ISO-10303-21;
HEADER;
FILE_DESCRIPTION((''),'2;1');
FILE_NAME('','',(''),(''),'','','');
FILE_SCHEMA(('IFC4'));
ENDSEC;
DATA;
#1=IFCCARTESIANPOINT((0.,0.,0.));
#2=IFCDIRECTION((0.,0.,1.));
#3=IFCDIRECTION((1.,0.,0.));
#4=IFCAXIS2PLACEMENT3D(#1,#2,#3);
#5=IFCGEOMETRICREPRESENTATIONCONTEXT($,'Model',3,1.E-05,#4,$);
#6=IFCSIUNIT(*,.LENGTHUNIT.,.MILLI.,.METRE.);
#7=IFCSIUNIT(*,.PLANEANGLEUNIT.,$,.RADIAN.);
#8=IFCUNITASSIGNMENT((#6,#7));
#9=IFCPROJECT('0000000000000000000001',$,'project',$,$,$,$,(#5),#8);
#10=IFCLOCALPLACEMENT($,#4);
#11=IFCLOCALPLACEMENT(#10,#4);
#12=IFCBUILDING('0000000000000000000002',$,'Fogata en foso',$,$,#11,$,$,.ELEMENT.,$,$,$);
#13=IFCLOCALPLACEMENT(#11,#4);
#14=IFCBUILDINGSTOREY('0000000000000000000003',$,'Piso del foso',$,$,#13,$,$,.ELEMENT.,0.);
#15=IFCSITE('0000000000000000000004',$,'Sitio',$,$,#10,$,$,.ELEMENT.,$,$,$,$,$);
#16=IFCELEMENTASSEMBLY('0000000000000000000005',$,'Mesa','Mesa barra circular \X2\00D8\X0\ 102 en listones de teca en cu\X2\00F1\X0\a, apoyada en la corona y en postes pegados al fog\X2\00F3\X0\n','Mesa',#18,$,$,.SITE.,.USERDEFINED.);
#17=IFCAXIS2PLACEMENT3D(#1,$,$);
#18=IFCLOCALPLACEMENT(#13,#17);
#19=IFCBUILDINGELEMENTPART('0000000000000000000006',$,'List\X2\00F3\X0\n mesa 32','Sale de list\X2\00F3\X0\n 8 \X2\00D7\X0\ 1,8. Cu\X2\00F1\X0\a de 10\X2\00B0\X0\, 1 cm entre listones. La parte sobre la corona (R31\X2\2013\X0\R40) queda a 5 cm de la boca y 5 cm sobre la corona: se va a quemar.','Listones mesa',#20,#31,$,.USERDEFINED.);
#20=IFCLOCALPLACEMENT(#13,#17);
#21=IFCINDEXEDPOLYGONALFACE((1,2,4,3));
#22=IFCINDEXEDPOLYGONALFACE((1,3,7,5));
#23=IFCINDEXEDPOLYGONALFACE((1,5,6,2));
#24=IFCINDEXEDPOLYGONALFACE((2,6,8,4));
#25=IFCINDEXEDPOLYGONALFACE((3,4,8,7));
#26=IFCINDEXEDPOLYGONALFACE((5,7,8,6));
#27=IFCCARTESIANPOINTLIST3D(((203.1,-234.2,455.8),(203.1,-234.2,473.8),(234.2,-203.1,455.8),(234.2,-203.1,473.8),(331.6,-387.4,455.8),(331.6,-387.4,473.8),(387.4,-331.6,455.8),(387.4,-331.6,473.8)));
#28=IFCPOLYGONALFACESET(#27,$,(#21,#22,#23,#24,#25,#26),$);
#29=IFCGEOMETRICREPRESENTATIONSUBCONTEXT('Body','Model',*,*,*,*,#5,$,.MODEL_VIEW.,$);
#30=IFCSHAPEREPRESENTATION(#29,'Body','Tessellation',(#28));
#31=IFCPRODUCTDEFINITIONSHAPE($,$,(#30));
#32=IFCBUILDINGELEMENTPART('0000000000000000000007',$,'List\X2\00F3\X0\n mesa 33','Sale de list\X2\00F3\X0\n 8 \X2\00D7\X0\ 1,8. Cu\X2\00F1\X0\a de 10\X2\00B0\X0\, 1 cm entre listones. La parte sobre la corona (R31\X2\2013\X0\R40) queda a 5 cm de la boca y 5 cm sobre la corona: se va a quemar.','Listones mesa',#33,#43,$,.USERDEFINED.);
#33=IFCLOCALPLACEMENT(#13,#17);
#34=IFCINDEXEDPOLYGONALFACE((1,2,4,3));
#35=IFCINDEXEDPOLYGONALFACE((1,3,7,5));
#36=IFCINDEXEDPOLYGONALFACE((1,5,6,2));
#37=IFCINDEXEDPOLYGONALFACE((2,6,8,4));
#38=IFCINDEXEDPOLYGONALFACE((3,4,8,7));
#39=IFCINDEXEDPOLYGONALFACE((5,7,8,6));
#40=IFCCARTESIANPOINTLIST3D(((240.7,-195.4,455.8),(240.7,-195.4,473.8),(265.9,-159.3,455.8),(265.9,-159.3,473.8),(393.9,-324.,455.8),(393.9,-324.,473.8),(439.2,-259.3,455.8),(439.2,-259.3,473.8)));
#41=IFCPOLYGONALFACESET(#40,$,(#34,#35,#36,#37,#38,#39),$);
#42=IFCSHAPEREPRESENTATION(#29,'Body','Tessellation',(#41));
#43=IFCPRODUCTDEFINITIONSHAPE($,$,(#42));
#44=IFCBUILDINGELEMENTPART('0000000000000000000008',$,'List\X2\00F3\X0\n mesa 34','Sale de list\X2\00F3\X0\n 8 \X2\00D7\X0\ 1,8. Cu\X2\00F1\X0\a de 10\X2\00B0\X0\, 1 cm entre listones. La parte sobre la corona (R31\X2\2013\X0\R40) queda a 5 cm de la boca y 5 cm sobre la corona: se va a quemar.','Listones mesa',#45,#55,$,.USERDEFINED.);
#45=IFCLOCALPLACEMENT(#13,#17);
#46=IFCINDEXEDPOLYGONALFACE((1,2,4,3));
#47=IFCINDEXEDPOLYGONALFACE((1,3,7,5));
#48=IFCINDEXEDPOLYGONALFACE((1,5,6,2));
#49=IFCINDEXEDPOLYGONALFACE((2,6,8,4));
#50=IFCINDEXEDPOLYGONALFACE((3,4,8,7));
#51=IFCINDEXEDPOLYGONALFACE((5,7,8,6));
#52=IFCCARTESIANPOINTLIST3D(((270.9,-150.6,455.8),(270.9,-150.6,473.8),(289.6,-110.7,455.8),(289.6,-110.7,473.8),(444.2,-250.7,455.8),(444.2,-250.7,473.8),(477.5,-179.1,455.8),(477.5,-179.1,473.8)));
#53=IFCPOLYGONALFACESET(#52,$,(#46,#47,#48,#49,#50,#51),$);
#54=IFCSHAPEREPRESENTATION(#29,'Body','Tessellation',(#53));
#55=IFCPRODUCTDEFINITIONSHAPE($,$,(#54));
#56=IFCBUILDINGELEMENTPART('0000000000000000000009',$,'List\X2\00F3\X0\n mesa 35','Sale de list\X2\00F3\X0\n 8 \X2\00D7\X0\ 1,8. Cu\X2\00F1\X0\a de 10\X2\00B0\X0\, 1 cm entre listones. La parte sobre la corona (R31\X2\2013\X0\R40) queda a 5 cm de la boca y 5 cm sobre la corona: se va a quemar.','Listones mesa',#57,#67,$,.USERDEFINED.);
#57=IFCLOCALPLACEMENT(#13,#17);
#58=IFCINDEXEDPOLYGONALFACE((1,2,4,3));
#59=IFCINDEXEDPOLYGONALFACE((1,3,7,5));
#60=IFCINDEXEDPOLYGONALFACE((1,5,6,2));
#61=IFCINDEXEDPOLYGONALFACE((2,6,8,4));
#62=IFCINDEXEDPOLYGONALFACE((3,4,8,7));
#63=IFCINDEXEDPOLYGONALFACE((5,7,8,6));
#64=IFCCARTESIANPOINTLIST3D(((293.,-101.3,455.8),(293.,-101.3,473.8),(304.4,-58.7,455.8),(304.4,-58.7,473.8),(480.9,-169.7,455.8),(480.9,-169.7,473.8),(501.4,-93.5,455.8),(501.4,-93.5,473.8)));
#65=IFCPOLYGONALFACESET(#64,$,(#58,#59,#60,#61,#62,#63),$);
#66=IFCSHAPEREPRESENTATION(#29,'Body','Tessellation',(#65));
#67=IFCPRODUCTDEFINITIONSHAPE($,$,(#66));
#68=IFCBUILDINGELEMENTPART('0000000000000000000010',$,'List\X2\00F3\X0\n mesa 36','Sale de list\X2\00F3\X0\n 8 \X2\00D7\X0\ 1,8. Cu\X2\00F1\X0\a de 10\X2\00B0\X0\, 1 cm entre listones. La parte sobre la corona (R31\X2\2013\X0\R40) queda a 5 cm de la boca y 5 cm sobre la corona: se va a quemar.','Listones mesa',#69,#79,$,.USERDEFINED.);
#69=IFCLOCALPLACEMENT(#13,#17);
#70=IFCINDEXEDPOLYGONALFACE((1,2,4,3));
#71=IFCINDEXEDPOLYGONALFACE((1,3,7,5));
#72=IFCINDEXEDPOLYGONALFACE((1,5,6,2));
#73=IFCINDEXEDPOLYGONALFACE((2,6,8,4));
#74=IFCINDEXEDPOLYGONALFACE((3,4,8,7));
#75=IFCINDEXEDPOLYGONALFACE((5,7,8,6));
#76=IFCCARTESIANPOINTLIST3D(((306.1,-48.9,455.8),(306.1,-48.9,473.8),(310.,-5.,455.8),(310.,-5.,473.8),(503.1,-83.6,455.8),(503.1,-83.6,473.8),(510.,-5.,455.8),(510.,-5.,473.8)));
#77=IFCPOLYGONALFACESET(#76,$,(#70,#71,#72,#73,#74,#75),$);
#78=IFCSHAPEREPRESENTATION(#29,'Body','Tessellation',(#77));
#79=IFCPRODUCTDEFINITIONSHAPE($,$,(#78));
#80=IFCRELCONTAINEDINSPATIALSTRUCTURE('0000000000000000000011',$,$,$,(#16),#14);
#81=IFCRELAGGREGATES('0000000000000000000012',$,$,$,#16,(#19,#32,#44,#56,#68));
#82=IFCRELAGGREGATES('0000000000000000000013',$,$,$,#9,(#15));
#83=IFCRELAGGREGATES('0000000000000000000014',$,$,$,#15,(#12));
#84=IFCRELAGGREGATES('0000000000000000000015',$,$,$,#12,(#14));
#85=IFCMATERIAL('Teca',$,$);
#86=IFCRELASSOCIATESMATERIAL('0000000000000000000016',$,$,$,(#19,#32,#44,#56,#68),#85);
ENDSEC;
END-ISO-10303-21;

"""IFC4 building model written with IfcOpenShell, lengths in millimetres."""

from ifc_helpers import new_model, si_unit, frame, origin_with_axes, place, context, subcontext, project, spatial, polyline, outline, extrude, material, element, aggregate, save


model = new_model("IFC4")

# Units and contexts
model_context = context("Model", 3, precision=1e-05, world=origin_with_axes())
body_context = subcontext(model_context, "Body", "Model", "MODEL_VIEW")
ifc_project = project(units=[si_unit("LENGTHUNIT", "METRE", prefix="MILLI"), si_unit("PLANEANGLEUNIT", "RADIAN")], contexts=[model_context])

# Site, building, storey
site_placement = place(None, origin_with_axes())
site = spatial("IfcSite", under=ifc_project, at=site_placement, Name="Sitio", CompositionType="ELEMENT")
building_placement = place(site_placement, origin_with_axes())
building = spatial("IfcBuilding", under=site, at=building_placement, Name="Fogata en foso", CompositionType="ELEMENT")
storey_placement = place(building_placement, origin_with_axes())
storey = spatial("IfcBuildingStorey", under=building, at=storey_placement, Name="Piso del foso", CompositionType="ELEMENT", Elevation=0.0)

# Element assembly, building element parts
ifc_material = material(Name="Teca")
assembly_1_placement = place(storey_placement, origin_with_axes())
assembly_1 = element("IfcElementAssembly", 1, at=assembly_1_placement, inside=storey, Name="Mesa", Description="Mesa barra circular Ø 102 en listones de teca en cuña, apoyada en la corona y en postes pegados al fogón", ObjectType="Mesa", AssemblyPlace="SITE", PredefinedType="USERDEFINED")
building_element_part_1_placement = place(storey_placement, frame((0.0, 0.0, 455.8), z_axis=(0.0, 0.0, 1.0), x_axis=(1.0, 0.0, 0.0)))
building_element_part_1 = element("IfcBuildingElementPart", 2, at=building_element_part_1_placement, material=ifc_material, Name="Listón mesa 32", Description="Sale de listón 8 × 1,8. Cuña de 10°, 1 cm entre listones. La parte sobre la corona (R31–R40) queda a 5 cm de la boca y 5 cm sobre la corona: se va a quemar.", ObjectType="Listones mesa", PredefinedType="USERDEFINED", context=body_context, shape_type="SweptSolid", body=[
    extrude(outline(polyline([(203.1, -234.2), (331.6, -387.4), (387.4, -331.6), (234.2, -203.1), (203.1, -234.2)])), origin_with_axes(), (0.0, 0.0, 1.0), 18.0),
])
building_element_part_2_placement = place(storey_placement, frame((0.0, 0.0, 455.8), z_axis=(0.0, 0.0, 1.0), x_axis=(1.0, 0.0, 0.0)))
building_element_part_2 = element("IfcBuildingElementPart", 3, at=building_element_part_2_placement, material=ifc_material, Name="Listón mesa 33", Description="Sale de listón 8 × 1,8. Cuña de 10°, 1 cm entre listones. La parte sobre la corona (R31–R40) queda a 5 cm de la boca y 5 cm sobre la corona: se va a quemar.", ObjectType="Listones mesa", PredefinedType="USERDEFINED", context=body_context, shape_type="SweptSolid", body=[
    extrude(outline(polyline([(240.7, -195.4), (393.9, -324.0), (439.2, -259.3), (265.9, -159.3), (240.7, -195.4)])), origin_with_axes(), (0.0, 0.0, 1.0), 18.0),
])
building_element_part_3_placement = place(storey_placement, frame((0.0, 0.0, 455.8), z_axis=(0.0, 0.0, 1.0), x_axis=(1.0, 0.0, 0.0)))
building_element_part_3 = element("IfcBuildingElementPart", 4, at=building_element_part_3_placement, material=ifc_material, Name="Listón mesa 34", Description="Sale de listón 8 × 1,8. Cuña de 10°, 1 cm entre listones. La parte sobre la corona (R31–R40) queda a 5 cm de la boca y 5 cm sobre la corona: se va a quemar.", ObjectType="Listones mesa", PredefinedType="USERDEFINED", context=body_context, shape_type="SweptSolid", body=[
    extrude(outline(polyline([(270.9, -150.7), (444.2, -250.7), (477.5, -179.1), (289.6, -110.7), (270.9, -150.7)])), origin_with_axes(), (0.0, 0.0, 1.0), 18.0),
])
building_element_part_4_placement = place(storey_placement, frame((0.0, 0.0, 455.8), z_axis=(0.0, 0.0, 1.0), x_axis=(1.0, 0.0, 0.0)))
building_element_part_4 = element("IfcBuildingElementPart", 5, at=building_element_part_4_placement, material=ifc_material, Name="Listón mesa 35", Description="Sale de listón 8 × 1,8. Cuña de 10°, 1 cm entre listones. La parte sobre la corona (R31–R40) queda a 5 cm de la boca y 5 cm sobre la corona: se va a quemar.", ObjectType="Listones mesa", PredefinedType="USERDEFINED", context=body_context, shape_type="SweptSolid", body=[
    extrude(outline(polyline([(293.0, -101.3), (480.9, -169.7), (501.4, -93.5), (304.4, -58.7), (293.0, -101.3)])), origin_with_axes(), (0.0, 0.0, 1.0), 18.0),
])
building_element_part_5_placement = place(storey_placement, frame((0.0, 0.0, 455.8), z_axis=(0.0, 0.0, 1.0), x_axis=(1.0, 0.0, 0.0)))
building_element_part_5 = element("IfcBuildingElementPart", 6, at=building_element_part_5_placement, material=ifc_material, Name="Listón mesa 36", Description="Sale de listón 8 × 1,8. Cuña de 10°, 1 cm entre listones. La parte sobre la corona (R31–R40) queda a 5 cm de la boca y 5 cm sobre la corona: se va a quemar.", ObjectType="Listones mesa", PredefinedType="USERDEFINED", context=body_context, shape_type="SweptSolid", body=[
    extrude(outline(polyline([(306.1, -48.9), (503.1, -83.6), (510.0, -5.0), (310.0, -5.0), (306.1, -48.9)])), origin_with_axes(), (0.0, 0.0, 1.0), 18.0),
])
aggregate(assembly_1, [building_element_part_1, building_element_part_2, building_element_part_3, building_element_part_4, building_element_part_5])

save(model, "model.ifc")
